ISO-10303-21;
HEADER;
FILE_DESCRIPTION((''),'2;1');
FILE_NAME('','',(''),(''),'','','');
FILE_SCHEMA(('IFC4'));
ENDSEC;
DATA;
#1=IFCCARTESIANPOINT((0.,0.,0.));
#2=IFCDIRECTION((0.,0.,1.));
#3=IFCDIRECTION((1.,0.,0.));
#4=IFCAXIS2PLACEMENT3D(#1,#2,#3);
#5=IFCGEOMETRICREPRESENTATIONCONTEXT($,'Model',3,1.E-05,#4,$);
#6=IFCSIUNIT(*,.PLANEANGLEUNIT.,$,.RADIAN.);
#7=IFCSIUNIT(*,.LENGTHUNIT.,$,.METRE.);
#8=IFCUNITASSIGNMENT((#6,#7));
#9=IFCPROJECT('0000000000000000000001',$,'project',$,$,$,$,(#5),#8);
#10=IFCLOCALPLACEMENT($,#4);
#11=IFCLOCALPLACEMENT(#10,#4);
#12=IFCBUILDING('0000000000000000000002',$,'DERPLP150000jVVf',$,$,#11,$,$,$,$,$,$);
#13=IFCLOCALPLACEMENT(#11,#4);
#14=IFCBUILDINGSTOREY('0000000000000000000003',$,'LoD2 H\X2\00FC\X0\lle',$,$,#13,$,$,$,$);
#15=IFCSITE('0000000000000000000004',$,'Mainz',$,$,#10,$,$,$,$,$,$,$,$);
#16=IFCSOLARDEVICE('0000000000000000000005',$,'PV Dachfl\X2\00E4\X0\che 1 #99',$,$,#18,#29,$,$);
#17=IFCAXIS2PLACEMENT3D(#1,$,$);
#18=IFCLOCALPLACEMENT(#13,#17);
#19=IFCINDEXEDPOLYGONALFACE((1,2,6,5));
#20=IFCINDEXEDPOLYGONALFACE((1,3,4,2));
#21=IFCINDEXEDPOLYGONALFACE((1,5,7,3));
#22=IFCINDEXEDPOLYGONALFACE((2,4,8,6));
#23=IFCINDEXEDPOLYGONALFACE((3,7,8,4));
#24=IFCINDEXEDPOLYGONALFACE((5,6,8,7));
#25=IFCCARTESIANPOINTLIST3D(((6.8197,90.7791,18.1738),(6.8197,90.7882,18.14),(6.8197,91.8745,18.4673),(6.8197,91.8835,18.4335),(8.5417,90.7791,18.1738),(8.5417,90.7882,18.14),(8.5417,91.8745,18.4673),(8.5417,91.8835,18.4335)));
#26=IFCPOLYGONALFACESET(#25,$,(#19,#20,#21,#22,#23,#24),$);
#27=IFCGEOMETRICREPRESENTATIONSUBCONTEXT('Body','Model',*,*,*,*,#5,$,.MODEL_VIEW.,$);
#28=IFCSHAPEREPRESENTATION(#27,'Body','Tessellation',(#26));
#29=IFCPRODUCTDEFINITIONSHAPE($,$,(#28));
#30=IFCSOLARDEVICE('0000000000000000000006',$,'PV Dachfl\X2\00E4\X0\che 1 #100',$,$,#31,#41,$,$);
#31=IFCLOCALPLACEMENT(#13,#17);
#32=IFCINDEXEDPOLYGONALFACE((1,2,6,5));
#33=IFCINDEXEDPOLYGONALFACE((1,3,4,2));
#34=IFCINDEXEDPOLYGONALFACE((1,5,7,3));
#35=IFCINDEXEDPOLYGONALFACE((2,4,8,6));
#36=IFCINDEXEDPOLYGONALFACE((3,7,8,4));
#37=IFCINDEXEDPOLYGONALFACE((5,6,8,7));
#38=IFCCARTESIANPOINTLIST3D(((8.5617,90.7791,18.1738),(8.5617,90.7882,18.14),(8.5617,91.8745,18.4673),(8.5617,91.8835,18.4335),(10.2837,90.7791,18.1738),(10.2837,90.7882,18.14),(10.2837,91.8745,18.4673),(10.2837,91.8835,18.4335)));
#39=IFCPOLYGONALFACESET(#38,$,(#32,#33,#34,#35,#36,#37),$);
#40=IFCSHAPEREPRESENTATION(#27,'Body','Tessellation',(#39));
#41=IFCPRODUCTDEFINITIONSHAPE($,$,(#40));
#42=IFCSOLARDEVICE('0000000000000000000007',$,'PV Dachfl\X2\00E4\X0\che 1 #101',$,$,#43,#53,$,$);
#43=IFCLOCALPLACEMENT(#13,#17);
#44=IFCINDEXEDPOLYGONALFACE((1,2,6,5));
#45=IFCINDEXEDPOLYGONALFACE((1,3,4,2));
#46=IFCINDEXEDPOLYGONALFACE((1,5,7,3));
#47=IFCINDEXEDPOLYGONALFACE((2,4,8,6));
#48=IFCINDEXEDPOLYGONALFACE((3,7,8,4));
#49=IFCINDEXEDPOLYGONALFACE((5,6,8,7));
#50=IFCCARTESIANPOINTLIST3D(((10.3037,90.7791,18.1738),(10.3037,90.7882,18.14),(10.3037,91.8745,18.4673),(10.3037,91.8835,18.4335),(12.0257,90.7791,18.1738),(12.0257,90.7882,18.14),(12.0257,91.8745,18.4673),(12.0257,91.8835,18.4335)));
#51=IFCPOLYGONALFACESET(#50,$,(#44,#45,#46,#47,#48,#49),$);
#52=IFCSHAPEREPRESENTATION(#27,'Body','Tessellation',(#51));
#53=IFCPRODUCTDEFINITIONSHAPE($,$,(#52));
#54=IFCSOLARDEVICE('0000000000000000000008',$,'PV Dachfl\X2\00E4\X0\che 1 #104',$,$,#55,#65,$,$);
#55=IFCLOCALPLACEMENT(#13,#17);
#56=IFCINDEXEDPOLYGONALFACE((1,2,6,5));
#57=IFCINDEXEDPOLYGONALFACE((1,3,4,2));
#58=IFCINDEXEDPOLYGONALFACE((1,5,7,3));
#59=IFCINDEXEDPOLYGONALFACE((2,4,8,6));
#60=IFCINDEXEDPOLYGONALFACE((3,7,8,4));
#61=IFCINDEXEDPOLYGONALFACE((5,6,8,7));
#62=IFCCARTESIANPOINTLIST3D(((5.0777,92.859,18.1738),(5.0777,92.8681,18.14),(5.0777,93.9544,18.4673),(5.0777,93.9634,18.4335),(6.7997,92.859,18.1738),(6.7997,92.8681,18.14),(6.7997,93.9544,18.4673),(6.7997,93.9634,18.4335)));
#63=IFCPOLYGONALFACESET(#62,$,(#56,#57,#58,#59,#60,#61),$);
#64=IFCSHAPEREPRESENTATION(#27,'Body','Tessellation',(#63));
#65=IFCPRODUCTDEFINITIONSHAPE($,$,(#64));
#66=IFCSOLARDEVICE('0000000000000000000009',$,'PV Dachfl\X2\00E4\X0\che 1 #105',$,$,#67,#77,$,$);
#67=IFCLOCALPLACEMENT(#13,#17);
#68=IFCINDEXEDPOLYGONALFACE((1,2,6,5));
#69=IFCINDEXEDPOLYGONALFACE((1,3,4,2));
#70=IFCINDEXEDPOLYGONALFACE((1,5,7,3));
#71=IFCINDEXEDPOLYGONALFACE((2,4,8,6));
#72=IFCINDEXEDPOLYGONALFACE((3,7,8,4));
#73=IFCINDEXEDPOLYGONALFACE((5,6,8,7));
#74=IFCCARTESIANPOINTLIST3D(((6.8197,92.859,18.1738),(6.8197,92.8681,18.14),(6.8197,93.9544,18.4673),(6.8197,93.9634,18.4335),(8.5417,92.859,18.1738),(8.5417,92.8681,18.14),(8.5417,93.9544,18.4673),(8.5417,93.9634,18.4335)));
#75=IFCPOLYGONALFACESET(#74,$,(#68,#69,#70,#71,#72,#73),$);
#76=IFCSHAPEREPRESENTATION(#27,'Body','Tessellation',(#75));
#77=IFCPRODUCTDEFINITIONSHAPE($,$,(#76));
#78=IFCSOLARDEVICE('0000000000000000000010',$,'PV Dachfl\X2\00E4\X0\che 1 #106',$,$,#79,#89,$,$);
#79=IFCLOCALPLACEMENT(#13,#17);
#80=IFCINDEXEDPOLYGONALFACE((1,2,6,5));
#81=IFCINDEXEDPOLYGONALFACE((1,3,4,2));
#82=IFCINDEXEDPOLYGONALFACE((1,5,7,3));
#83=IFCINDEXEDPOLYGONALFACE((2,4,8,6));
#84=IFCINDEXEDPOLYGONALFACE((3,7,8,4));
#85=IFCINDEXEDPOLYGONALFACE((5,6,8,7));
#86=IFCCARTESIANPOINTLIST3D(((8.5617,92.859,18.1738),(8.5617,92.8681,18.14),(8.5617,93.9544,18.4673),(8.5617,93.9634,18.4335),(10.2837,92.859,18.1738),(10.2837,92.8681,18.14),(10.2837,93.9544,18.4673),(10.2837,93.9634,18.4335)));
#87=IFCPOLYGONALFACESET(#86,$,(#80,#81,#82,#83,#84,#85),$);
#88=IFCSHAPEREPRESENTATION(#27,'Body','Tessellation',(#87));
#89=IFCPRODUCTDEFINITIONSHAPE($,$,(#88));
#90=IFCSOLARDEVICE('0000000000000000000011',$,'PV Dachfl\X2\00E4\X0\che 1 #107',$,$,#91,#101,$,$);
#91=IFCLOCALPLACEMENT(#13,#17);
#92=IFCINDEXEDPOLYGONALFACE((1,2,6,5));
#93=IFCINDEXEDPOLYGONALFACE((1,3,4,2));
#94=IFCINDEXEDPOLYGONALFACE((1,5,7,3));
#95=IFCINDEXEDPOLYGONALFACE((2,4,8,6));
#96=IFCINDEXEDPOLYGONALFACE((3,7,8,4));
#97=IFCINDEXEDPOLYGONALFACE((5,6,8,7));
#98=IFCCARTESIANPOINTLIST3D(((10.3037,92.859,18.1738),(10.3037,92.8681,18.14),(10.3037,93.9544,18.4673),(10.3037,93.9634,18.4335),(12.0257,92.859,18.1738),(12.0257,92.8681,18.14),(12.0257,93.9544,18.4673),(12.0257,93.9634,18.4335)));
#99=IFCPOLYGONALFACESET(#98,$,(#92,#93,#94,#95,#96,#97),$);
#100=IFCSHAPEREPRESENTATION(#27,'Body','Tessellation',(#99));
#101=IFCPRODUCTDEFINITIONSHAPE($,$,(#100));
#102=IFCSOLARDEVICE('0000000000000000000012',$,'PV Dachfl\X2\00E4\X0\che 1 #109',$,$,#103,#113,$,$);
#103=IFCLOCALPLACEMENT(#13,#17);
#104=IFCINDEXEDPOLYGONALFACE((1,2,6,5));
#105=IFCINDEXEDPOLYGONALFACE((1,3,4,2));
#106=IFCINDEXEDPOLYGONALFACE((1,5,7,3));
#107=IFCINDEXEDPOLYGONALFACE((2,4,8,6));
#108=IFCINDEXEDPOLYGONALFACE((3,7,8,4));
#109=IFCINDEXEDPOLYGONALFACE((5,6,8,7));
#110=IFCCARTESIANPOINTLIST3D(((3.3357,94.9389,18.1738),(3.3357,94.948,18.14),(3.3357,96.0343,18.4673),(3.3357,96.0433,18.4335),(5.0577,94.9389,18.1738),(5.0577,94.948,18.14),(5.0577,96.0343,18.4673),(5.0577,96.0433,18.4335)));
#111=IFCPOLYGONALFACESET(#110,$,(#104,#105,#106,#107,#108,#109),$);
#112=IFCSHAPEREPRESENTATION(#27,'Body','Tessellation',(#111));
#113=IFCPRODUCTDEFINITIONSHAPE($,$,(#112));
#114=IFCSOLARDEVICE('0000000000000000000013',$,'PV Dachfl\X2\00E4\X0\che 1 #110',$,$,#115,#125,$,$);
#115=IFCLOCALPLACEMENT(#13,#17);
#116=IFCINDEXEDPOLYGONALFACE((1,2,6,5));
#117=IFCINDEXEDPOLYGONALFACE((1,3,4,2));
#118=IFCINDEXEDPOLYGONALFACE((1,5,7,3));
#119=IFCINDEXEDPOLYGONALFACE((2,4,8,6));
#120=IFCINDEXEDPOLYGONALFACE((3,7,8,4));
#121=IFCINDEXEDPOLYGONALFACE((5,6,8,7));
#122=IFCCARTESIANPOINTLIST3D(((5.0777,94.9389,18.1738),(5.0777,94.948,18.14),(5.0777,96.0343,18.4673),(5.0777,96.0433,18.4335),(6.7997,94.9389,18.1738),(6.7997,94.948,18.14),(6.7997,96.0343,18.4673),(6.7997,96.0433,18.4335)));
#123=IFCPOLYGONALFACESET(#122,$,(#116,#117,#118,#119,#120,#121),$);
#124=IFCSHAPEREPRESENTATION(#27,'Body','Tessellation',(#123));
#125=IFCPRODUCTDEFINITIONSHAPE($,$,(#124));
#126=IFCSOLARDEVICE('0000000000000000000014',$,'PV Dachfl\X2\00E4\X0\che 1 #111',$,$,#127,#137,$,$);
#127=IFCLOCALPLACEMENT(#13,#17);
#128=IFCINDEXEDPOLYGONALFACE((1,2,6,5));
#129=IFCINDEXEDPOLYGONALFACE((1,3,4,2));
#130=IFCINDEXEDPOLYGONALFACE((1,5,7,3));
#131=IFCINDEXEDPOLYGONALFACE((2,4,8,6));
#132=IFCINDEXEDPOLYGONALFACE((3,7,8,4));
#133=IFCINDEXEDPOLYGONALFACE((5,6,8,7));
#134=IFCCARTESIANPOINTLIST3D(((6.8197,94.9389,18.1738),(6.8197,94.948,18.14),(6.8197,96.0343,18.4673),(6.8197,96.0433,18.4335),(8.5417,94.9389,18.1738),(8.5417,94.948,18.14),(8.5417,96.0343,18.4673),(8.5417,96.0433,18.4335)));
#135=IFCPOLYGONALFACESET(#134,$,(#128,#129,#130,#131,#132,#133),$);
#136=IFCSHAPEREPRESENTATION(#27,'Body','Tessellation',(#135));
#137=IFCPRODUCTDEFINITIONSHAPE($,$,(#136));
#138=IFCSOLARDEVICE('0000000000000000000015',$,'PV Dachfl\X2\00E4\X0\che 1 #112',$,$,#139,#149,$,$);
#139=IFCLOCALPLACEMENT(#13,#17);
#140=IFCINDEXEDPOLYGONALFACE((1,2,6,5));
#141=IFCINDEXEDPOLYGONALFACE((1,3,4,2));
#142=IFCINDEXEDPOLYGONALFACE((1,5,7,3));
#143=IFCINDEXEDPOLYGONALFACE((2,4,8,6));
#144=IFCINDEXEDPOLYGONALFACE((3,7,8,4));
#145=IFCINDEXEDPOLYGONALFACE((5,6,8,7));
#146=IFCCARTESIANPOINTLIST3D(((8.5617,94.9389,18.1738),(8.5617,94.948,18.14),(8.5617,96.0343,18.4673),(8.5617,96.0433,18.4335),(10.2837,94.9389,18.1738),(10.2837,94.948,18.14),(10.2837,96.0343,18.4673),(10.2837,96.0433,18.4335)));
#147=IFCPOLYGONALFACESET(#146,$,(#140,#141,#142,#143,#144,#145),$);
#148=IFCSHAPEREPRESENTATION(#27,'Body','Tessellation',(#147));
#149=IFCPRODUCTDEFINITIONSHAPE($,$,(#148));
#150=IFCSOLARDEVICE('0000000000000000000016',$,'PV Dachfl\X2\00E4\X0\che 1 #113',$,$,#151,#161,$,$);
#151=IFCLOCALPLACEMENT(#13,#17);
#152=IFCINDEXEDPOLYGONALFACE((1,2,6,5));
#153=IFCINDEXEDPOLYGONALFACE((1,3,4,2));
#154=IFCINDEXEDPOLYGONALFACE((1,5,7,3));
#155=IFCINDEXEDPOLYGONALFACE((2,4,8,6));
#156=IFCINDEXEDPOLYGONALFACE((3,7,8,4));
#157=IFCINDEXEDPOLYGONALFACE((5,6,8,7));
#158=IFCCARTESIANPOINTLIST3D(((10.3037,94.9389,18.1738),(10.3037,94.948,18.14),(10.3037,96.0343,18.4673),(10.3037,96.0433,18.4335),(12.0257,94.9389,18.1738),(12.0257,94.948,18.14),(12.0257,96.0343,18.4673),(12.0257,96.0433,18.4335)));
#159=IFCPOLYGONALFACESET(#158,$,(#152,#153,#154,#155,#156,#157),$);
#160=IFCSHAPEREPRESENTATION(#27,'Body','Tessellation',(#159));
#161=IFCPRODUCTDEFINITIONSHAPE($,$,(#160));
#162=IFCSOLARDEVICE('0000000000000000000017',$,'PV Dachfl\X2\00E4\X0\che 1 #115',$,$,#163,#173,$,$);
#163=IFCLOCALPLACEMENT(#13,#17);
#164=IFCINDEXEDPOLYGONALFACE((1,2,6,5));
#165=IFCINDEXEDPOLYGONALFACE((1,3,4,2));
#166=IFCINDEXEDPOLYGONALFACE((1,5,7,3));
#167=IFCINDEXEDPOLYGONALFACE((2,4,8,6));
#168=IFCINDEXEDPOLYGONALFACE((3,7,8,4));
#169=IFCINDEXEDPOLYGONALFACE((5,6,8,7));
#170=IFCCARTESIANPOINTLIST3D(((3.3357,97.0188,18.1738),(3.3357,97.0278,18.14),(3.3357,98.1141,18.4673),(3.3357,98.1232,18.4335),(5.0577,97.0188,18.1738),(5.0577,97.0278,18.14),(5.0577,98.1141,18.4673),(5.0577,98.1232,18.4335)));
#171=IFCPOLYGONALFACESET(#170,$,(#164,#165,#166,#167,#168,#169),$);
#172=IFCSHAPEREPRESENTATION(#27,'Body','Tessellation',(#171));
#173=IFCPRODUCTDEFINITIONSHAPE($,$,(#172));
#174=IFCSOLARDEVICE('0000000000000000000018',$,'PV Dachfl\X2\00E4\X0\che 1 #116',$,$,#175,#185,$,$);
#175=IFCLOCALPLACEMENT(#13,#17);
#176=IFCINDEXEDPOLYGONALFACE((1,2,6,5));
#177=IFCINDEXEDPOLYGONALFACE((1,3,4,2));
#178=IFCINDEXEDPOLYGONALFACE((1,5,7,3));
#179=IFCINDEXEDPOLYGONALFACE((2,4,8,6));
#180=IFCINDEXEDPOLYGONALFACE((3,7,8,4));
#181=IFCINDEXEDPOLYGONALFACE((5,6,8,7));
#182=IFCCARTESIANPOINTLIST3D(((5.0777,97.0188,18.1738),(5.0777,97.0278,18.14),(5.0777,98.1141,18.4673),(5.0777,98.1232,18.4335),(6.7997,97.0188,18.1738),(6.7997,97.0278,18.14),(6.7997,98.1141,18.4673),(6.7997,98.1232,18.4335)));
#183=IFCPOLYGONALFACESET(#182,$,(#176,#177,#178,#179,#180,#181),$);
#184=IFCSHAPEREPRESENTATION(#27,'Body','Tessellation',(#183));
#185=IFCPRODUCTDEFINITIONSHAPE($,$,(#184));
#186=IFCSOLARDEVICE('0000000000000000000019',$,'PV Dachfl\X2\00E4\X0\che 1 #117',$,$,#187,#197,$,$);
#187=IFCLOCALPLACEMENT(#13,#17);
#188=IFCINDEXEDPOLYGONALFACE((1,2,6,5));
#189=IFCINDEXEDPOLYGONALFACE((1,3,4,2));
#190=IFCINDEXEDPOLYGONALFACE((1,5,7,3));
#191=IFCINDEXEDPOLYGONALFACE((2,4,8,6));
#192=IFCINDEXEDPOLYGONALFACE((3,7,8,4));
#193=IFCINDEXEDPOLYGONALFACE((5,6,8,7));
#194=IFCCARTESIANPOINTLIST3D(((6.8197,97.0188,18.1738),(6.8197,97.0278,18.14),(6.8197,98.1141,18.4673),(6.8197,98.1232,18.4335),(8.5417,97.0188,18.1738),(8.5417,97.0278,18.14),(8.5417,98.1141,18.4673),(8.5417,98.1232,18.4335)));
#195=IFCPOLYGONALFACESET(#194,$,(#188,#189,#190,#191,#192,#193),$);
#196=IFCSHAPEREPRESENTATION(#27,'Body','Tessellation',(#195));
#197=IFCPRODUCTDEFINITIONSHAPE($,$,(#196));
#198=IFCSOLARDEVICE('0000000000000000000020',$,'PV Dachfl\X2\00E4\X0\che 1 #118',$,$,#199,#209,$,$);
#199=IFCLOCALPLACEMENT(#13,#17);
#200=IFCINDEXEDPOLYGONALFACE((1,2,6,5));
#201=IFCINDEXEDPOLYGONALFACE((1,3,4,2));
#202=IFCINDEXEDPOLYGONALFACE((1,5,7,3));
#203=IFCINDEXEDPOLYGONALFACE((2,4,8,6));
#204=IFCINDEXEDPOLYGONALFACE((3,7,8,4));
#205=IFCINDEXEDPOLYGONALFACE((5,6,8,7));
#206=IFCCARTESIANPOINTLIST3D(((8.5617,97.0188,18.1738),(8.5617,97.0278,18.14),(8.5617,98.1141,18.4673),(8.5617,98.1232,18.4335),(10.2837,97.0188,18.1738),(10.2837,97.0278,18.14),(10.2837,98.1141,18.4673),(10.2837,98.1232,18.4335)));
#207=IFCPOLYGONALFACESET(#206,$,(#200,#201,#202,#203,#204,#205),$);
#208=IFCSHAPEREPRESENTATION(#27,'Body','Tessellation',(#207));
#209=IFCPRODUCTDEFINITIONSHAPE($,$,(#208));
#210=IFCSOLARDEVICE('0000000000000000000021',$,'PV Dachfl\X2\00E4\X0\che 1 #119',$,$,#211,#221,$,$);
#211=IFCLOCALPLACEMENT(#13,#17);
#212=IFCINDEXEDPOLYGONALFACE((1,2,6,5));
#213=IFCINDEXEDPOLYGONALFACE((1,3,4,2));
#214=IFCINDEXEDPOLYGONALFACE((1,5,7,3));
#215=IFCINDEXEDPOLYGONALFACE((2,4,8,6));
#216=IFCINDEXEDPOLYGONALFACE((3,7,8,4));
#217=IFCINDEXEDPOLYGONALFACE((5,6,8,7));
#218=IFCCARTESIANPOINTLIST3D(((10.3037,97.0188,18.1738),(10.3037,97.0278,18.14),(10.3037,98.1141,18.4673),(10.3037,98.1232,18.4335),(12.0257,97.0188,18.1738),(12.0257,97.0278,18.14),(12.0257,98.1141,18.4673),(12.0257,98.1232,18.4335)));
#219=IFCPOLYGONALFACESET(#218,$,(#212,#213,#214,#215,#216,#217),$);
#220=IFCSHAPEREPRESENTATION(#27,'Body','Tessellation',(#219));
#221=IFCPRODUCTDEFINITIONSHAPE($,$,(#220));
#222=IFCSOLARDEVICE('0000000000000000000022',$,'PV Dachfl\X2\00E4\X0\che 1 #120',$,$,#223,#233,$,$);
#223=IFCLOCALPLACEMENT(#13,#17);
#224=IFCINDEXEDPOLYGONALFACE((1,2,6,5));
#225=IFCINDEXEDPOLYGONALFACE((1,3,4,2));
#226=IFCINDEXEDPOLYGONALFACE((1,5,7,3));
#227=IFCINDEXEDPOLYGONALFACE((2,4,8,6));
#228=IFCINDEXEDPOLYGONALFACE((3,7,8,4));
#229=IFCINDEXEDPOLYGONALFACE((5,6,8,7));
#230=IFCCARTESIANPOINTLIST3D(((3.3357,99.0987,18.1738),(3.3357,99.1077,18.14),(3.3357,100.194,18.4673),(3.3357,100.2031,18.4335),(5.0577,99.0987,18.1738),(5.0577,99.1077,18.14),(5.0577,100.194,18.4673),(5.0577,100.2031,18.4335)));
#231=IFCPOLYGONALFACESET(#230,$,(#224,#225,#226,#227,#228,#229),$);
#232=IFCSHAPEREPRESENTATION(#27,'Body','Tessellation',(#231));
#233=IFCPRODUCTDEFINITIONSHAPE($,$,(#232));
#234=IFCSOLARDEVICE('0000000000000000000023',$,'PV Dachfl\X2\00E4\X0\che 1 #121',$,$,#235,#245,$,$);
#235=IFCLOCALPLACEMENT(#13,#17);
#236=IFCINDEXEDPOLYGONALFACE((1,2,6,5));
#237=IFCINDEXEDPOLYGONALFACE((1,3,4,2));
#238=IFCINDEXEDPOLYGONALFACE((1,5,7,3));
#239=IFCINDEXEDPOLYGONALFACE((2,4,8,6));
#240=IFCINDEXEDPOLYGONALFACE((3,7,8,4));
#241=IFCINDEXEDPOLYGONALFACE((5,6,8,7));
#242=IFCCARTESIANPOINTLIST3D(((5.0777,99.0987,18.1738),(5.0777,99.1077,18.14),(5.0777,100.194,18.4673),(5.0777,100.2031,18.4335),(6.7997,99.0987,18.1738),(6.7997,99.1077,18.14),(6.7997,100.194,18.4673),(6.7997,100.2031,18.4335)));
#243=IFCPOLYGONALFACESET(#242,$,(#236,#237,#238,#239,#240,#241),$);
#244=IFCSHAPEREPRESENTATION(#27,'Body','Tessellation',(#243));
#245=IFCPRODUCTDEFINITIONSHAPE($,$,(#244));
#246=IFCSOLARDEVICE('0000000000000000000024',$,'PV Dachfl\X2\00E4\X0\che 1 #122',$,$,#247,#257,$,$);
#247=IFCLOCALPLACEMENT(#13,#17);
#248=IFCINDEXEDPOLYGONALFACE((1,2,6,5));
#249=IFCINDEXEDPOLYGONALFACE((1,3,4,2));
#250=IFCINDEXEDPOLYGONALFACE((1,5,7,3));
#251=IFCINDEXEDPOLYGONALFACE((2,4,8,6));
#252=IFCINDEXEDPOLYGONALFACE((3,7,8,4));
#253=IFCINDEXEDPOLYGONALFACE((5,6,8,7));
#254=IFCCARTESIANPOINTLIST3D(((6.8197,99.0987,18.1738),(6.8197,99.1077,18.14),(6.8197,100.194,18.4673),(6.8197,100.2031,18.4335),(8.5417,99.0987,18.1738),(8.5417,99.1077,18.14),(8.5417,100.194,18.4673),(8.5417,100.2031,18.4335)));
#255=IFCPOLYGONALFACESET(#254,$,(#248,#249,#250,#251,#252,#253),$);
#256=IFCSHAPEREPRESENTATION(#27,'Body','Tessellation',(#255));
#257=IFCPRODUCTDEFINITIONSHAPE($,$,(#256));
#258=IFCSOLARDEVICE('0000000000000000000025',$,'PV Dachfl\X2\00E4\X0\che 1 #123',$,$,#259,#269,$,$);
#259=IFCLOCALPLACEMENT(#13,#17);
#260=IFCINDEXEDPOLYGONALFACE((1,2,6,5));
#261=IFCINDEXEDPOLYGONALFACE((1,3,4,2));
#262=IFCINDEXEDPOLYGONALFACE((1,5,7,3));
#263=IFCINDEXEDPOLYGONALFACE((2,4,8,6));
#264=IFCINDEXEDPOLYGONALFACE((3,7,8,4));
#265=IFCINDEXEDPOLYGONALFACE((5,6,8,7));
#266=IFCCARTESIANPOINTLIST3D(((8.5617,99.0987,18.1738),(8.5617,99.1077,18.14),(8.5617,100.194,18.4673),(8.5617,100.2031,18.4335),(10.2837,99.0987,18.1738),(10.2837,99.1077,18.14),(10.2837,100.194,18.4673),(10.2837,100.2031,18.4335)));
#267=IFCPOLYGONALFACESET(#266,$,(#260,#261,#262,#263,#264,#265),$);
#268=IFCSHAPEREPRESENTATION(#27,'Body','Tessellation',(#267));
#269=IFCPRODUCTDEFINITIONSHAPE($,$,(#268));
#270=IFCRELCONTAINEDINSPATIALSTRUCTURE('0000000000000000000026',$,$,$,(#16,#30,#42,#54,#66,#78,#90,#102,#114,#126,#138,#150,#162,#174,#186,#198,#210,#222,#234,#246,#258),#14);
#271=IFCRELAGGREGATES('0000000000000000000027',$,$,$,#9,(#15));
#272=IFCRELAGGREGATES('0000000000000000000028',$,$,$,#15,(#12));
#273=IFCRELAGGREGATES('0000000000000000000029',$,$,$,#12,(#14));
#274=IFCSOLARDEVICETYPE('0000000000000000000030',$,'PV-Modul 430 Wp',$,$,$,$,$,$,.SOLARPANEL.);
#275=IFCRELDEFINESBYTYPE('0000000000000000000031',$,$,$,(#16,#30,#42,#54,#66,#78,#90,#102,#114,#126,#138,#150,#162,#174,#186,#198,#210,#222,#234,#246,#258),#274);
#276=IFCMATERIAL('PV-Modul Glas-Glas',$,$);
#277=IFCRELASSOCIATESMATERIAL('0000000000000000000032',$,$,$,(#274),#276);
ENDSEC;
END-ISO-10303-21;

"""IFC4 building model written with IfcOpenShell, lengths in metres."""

from ifc_helpers import new_model, si_unit, frame, frame_2d, origin, origin_with_axes, place, context, subcontext, project, spatial, rectangle, extrude, source, transform, mapped, material, type_object, type_shapes, element, save


model = new_model("IFC4")

# Units and contexts
model_context = context("Model", 3, precision=1e-05, world=origin_with_axes())
body_context = subcontext(model_context, "Body", "Model", "MODEL_VIEW")
ifc_project = project(units=[si_unit("PLANEANGLEUNIT", "RADIAN"), si_unit("LENGTHUNIT", "METRE")], contexts=[model_context])

# Site, building, storey
site_placement = place(None, origin_with_axes())
site = spatial("IfcSite", under=ifc_project, at=site_placement, Name="Mainz")
building_placement = place(site_placement, origin_with_axes())
building = spatial("IfcBuilding", under=site, at=building_placement, Name="DERPLP150000jVVf")
storey_placement = place(building_placement, origin_with_axes())
storey = spatial("IfcBuildingStorey", under=building, at=storey_placement, Name="LoD2 Hülle")

# Solar devices
ifc_material = material(Name="PV-Modul Glas-Glas")
solar_device_type = type_object("IfcSolarDeviceType", Name="PV-Modul 430 Wp", PredefinedType="SOLARPANEL", material=ifc_material)
shared_shape = source(origin_with_axes(), body_context, "Body", "SweptSolid", [
    extrude(rectangle(XDim=1.722, YDim=1.134, at=frame_2d((0.861, 0.567))), origin(), (0.0, 0.0, 1.0), 0.035),
])
type_shapes(solar_device_type, [shared_shape])
for number, where, z_axis, x_axis, name in (
    (1, (6.8197, 90.7882, 18.14), (0.0, -0.258819, 0.965926), (1.0, 0.0, 0.0), "PV Dachfläche 1 #99"),
    (2, (8.5617, 90.7882, 18.14), (0.0, -0.258819, 0.965926), (1.0, 0.0, 0.0), "PV Dachfläche 1 #100"),
    (3, (10.3037, 90.7882, 18.14), (0.0, -0.258819, 0.965926), (1.0, 0.0, 0.0), "PV Dachfläche 1 #101"),
    (4, (5.0777, 92.8681, 18.14), (0.0, -0.258819, 0.965926), (1.0, 0.0, 0.0), "PV Dachfläche 1 #104"),
    (5, (6.8197, 92.8681, 18.14), (0.0, -0.258819, 0.965926), (1.0, 0.0, 0.0), "PV Dachfläche 1 #105"),
    (6, (8.5617, 92.8681, 18.14), (0.0, -0.258819, 0.965926), (1.0, 0.0, 0.0), "PV Dachfläche 1 #106"),
    (7, (10.3037, 92.8681, 18.14), (0.0, -0.258819, 0.965926), (1.0, 0.0, 0.0), "PV Dachfläche 1 #107"),
    (8, (3.3357, 94.948, 18.14), (0.0, -0.258819, 0.965926), (1.0, 0.0, 0.0), "PV Dachfläche 1 #109"),
    (9, (5.0777, 94.948, 18.14), (0.0, -0.258819, 0.965926), (1.0, 0.0, 0.0), "PV Dachfläche 1 #110"),
    (10, (6.8197, 94.948, 18.14), (0.0, -0.258819, 0.965926), (1.0, 0.0, 0.0), "PV Dachfläche 1 #111"),
    (11, (8.5617, 94.948, 18.14), (0.0, -0.258819, 0.965926), (1.0, 0.0, 0.0), "PV Dachfläche 1 #112"),
    (12, (10.3037, 94.948, 18.14), (0.0, -0.258819, 0.965926), (1.0, 0.0, 0.0), "PV Dachfläche 1 #113"),
    (13, (3.3357, 97.0278, 18.14), (0.0, -0.258819, 0.965926), (1.0, 0.0, 0.0), "PV Dachfläche 1 #115"),
    (14, (5.0777, 97.0278, 18.14), (0.0, -0.258819, 0.965926), (1.0, 0.0, 0.0), "PV Dachfläche 1 #116"),
    (15, (6.8197, 97.0278, 18.14), (0.0, -0.258819, 0.965926), (1.0, 0.0, 0.0), "PV Dachfläche 1 #117"),
    (16, (8.5617, 97.0278, 18.14), (0.0, -0.258819, 0.965926), (1.0, 0.0, 0.0), "PV Dachfläche 1 #118"),
    (17, (10.3037, 97.0278, 18.14), (0.0, -0.258819, 0.965926), (1.0, 0.0, 0.0), "PV Dachfläche 1 #119"),
    (18, (3.3357, 99.1077, 18.14), (0.0, -0.258819, 0.965926), (1.0, 0.0, 0.0), "PV Dachfläche 1 #120"),
    (19, (5.0777, 99.1077, 18.14), (0.0, -0.258819, 0.965926), (1.0, 0.0, 0.0), "PV Dachfläche 1 #121"),
    (20, (6.8197, 99.1077, 18.14), (0.0, -0.258819, 0.965926), (1.0, 0.0, 0.0), "PV Dachfläche 1 #122"),
    (21, (8.5617, 99.1077, 18.14), (0.0, -0.258819, 0.965926), (1.0, 0.0, 0.0), "PV Dachfläche 1 #123"),
):
    element("IfcSolarDevice", number, at=place(storey_placement, frame(where, z_axis=z_axis, x_axis=x_axis)), inside=storey, type_object=solar_device_type, Name=name, context=body_context, shape_type="MappedRepresentation", body=[
        mapped(shared_shape, transform((0.0, 0.0, 0.0), x_axis=(1.0, 0.0, 0.0), y_axis=(0.0, 1.0, 0.0), z_axis=(0.0, 0.0, 1.0), scale=1.0)),
    ])

save(model, "model.ifc")
